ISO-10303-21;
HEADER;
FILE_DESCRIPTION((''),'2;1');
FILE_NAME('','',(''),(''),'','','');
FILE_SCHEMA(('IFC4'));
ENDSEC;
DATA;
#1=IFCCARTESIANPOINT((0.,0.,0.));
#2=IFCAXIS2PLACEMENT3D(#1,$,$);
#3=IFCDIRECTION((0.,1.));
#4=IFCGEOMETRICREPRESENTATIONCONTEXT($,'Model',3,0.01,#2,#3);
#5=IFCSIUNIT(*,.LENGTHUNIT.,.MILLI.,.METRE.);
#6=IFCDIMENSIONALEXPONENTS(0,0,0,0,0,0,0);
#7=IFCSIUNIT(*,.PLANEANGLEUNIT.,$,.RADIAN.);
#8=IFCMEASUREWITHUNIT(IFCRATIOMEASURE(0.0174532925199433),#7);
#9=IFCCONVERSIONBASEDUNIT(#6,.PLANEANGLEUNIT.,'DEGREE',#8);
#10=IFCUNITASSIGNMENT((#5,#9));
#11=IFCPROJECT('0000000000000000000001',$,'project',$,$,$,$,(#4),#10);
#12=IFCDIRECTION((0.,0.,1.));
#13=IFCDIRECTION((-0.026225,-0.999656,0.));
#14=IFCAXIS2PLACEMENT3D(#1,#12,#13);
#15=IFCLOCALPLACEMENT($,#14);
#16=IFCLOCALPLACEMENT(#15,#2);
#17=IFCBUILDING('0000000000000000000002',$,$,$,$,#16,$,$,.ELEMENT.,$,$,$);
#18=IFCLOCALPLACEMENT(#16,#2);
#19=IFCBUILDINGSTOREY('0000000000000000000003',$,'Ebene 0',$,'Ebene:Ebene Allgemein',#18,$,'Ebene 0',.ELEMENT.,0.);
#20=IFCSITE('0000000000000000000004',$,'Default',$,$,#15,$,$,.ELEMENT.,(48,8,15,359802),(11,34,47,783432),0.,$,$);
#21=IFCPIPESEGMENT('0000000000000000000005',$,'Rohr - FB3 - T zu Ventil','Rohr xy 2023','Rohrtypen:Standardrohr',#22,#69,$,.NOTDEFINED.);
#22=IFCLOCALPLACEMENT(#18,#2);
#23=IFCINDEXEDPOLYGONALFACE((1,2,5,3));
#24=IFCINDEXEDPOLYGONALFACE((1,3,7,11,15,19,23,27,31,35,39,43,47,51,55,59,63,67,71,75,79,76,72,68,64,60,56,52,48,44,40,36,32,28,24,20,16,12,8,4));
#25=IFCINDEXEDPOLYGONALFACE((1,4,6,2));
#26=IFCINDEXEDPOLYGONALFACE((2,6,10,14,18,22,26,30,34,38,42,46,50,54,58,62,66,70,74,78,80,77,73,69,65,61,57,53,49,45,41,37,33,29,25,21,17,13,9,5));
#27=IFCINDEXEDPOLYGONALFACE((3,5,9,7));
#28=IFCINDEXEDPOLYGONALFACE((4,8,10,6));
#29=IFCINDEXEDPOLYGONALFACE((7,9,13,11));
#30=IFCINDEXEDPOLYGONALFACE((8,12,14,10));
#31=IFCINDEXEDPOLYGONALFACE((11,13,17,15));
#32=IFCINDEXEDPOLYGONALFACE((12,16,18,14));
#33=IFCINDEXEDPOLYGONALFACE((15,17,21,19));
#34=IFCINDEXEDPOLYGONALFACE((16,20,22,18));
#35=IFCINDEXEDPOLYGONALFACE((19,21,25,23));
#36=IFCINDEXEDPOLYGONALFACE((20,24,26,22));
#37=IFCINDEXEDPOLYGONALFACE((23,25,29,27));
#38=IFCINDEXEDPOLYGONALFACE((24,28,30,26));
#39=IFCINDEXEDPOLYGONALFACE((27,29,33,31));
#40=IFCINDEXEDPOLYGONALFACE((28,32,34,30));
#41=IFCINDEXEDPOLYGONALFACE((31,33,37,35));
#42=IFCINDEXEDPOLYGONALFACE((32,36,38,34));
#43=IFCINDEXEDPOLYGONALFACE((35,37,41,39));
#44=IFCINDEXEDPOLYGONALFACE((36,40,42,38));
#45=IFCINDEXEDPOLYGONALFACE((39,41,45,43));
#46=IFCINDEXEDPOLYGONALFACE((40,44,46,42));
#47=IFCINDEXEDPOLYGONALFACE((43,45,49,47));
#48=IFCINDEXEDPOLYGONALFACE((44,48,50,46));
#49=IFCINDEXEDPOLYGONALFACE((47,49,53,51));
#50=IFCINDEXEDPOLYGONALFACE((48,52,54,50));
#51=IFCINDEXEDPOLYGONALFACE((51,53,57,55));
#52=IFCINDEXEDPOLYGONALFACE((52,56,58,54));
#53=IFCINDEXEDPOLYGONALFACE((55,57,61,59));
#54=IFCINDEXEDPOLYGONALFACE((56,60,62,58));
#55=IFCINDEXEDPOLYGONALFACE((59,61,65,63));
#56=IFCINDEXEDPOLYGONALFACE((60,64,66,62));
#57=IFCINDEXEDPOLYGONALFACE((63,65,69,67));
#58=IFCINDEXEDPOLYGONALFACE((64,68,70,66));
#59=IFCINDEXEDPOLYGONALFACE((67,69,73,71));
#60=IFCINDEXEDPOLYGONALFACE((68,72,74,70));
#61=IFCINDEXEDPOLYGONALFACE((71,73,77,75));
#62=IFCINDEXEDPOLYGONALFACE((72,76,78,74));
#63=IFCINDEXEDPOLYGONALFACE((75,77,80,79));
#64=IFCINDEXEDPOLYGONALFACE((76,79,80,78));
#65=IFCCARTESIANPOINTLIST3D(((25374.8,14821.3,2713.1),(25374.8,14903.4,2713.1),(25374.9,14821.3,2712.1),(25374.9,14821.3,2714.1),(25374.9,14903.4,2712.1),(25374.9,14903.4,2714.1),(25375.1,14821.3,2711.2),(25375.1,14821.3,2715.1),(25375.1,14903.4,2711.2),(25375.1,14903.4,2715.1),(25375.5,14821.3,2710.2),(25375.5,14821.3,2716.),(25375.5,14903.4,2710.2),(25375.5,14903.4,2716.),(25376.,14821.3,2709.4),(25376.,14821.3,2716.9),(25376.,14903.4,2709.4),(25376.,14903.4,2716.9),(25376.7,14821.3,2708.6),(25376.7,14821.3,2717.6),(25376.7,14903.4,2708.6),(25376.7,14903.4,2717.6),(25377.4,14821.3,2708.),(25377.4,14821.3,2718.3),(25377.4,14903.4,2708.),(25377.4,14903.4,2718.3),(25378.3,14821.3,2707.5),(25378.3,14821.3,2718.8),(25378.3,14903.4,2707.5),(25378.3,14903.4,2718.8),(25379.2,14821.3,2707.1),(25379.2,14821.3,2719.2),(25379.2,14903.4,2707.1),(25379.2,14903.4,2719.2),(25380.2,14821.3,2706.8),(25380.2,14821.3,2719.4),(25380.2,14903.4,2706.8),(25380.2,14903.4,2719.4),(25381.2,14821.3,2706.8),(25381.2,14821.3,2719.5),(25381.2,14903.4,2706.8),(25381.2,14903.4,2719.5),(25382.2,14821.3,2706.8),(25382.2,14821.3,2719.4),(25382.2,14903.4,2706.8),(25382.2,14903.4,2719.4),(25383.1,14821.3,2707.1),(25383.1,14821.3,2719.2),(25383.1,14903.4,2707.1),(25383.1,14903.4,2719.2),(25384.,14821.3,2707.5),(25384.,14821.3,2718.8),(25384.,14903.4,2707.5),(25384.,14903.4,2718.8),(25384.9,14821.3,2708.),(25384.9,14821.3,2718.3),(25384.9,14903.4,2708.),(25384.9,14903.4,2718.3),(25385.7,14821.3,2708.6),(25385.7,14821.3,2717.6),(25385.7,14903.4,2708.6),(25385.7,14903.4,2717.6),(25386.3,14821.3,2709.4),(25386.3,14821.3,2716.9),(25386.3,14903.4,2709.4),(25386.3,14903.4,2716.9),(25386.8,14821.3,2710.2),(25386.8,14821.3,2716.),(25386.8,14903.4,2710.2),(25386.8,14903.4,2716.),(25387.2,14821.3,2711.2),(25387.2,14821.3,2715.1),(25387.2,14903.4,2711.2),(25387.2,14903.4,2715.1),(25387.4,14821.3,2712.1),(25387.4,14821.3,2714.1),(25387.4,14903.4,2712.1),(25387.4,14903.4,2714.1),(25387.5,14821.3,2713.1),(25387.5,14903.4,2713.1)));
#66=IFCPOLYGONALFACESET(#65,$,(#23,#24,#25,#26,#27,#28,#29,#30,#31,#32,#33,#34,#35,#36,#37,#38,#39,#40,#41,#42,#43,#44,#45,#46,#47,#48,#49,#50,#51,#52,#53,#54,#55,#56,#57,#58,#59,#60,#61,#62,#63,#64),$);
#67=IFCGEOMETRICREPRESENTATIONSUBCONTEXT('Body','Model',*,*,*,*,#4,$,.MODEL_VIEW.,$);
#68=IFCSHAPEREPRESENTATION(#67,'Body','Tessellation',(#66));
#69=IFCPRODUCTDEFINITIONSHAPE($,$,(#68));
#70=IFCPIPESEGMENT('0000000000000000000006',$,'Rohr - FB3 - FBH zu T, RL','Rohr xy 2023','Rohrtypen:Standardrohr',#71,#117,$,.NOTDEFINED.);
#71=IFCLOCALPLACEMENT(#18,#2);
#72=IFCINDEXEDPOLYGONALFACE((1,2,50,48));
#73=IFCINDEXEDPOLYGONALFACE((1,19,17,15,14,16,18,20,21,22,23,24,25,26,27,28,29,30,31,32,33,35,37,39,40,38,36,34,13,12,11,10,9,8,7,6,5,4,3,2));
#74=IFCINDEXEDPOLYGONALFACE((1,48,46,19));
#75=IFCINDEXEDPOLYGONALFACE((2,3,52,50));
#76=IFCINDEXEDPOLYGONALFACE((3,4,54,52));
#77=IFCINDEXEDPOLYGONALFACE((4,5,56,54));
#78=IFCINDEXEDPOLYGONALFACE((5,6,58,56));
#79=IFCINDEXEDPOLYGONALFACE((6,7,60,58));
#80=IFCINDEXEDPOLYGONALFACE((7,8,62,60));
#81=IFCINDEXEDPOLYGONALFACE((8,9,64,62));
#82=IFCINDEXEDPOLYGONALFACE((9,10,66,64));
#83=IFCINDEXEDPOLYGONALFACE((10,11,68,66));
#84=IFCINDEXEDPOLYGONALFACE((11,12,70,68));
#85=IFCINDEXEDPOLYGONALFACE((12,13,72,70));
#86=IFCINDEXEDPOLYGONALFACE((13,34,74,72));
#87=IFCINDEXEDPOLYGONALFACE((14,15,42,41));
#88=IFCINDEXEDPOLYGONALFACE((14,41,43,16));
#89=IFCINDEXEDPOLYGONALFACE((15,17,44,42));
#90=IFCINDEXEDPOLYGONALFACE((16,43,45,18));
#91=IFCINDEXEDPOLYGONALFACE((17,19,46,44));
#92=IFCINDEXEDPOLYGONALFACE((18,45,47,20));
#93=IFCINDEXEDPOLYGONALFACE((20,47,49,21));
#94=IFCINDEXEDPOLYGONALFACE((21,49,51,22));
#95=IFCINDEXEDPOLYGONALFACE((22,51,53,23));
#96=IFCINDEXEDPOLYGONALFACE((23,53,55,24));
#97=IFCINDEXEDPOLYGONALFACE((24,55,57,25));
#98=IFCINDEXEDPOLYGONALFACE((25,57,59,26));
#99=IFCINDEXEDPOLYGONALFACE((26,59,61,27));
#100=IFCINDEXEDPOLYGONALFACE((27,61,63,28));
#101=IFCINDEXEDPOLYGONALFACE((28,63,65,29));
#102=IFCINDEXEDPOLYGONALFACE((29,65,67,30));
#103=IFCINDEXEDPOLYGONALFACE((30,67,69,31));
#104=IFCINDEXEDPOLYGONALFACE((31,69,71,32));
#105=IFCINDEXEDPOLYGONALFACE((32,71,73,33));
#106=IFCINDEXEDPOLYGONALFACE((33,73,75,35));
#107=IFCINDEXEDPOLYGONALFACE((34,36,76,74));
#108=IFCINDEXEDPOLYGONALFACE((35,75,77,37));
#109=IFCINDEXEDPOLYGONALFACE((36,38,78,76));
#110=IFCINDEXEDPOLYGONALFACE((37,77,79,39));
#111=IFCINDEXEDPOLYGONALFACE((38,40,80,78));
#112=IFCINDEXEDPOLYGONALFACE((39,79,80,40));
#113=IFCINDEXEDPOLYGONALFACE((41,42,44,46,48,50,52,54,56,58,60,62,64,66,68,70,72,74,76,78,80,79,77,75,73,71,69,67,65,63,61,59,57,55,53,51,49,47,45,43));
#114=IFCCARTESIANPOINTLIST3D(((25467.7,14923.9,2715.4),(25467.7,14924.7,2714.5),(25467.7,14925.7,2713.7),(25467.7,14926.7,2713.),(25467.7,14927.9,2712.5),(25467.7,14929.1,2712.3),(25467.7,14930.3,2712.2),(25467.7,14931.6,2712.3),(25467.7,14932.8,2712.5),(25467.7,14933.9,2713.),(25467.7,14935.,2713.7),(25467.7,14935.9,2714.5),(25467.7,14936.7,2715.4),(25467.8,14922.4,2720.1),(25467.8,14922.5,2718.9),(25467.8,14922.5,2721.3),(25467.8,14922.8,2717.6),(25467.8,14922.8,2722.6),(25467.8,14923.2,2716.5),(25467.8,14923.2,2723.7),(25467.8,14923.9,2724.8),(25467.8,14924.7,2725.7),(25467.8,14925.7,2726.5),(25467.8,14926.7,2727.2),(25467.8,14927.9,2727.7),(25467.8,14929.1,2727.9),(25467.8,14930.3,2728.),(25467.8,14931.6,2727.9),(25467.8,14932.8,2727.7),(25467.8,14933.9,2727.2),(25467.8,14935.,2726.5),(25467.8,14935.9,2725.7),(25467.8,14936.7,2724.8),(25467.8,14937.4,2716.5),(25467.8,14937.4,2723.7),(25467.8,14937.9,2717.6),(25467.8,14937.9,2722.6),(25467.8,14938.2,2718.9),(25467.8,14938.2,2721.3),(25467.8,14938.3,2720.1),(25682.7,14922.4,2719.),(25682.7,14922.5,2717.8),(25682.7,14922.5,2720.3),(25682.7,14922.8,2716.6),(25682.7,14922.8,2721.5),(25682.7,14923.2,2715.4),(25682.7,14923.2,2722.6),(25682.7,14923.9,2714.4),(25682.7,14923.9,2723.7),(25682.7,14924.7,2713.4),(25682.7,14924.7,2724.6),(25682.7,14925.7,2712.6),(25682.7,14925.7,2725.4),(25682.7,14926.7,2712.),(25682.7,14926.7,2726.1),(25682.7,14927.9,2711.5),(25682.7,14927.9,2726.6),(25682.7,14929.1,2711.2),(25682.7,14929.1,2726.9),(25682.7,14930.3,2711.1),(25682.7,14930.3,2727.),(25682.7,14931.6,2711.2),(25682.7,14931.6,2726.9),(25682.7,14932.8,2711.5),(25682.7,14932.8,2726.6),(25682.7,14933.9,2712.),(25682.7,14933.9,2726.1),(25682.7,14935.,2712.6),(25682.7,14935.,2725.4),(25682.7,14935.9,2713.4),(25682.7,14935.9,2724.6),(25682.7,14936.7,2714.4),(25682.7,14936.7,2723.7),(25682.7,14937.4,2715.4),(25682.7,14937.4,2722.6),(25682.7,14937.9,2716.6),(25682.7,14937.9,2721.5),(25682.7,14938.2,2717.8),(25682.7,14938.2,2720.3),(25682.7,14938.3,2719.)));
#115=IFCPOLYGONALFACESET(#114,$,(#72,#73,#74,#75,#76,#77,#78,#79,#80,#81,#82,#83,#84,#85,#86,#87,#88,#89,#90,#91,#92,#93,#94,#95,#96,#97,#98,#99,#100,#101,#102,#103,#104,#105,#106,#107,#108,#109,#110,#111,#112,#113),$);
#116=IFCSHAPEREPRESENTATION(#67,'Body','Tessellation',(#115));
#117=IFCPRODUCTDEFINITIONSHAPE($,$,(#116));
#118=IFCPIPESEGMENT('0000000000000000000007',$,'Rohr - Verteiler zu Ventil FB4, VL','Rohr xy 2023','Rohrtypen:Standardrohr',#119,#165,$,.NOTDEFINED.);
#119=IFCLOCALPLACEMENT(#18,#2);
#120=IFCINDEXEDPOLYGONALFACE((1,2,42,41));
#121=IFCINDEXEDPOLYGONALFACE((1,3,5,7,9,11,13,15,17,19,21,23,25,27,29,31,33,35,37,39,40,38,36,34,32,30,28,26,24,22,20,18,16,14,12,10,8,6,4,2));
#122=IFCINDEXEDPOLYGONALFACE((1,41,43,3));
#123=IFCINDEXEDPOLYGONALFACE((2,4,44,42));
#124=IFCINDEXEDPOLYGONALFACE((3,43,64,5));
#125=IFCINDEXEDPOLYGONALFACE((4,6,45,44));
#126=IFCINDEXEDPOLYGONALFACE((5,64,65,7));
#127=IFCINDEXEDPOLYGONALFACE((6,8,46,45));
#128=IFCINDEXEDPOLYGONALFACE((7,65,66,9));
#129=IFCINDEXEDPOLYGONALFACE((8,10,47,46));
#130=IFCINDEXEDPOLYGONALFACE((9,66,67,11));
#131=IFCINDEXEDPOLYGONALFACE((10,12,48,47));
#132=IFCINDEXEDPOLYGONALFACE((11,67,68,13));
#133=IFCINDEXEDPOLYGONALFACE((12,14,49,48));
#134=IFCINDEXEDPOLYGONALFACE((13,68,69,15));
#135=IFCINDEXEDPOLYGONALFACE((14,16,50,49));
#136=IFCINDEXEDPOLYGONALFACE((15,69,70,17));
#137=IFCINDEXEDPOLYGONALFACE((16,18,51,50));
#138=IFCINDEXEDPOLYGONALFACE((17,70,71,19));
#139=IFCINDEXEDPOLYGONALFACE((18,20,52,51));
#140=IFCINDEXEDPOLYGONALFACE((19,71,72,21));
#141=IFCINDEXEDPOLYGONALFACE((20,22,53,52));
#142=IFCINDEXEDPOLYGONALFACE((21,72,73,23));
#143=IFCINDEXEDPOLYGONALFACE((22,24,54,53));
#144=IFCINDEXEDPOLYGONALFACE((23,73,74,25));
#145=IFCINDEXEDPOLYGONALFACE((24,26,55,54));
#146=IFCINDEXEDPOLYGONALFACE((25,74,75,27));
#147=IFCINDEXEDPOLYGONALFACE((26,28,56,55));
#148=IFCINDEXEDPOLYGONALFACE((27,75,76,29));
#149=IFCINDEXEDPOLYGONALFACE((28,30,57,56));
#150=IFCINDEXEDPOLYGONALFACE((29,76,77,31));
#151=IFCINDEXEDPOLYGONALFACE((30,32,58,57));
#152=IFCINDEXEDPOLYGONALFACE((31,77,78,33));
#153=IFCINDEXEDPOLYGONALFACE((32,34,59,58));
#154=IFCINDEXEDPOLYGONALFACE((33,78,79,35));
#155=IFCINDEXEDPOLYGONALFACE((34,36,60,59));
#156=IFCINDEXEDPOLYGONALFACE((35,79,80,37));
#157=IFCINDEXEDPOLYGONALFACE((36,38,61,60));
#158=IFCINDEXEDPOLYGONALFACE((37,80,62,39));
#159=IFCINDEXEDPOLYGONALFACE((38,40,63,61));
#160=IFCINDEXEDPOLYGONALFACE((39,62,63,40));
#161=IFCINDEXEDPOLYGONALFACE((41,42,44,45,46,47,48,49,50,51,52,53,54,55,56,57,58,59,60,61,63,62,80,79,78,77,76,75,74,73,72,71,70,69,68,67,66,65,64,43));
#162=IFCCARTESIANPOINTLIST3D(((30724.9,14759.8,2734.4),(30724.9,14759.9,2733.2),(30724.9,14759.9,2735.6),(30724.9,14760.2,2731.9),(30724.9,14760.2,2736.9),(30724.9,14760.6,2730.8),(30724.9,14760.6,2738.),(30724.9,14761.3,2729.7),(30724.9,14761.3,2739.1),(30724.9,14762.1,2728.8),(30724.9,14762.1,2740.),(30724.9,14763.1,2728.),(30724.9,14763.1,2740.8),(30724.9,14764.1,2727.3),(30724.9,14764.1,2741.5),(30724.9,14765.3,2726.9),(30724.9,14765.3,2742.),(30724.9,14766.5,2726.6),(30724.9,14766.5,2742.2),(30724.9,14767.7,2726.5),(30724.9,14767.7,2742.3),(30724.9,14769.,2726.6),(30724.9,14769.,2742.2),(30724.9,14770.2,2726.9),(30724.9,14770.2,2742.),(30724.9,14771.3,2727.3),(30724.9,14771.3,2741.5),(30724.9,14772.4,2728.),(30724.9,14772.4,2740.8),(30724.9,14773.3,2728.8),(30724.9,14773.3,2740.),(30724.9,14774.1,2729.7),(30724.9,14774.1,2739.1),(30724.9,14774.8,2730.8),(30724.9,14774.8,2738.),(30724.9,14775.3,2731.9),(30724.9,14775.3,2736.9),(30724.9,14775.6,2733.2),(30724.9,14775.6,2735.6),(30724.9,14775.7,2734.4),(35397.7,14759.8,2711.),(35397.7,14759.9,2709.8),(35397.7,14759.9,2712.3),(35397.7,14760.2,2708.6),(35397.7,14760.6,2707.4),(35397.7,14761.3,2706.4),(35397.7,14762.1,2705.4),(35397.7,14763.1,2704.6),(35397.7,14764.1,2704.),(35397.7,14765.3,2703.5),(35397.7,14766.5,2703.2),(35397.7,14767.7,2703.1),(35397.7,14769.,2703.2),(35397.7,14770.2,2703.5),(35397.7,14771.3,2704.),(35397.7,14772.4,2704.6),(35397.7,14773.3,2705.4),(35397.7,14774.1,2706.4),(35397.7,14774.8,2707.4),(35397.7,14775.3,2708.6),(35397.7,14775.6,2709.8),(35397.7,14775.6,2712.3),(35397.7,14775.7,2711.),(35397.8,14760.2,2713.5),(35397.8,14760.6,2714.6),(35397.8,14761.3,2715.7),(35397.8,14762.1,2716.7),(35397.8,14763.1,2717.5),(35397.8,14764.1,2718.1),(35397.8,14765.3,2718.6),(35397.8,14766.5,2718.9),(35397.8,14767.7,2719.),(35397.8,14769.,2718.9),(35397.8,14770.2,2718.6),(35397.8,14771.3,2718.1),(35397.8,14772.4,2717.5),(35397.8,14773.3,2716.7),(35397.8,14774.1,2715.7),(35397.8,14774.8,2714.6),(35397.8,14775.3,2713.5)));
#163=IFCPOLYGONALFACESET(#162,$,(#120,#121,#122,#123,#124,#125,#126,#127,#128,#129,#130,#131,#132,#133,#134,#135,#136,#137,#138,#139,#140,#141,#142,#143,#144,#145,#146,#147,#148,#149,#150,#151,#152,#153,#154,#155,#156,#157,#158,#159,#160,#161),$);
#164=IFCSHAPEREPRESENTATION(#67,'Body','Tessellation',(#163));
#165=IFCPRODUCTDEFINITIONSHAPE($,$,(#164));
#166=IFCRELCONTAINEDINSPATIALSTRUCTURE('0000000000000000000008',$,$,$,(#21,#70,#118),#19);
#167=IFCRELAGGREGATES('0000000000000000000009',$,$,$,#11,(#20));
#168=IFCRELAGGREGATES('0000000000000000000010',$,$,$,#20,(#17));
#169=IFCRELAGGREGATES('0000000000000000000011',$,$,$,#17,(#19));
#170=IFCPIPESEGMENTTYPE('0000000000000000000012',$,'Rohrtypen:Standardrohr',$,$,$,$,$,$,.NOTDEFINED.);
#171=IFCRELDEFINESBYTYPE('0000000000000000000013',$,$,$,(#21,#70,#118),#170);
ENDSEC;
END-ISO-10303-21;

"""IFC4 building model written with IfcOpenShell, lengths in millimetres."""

from ifc_helpers import new_model, entity, si_unit, converted_unit, direction, frame, origin, place, context, subcontext, project, spatial, indexed_curve, outline, extrude, type_object, element, save


model = new_model("IFC4")

# Units and contexts
model_context = context("Model", 3, precision=0.01, world=origin(), true_north=direction((0.0, 1.0)))
body_context = subcontext(model_context, "Body", "Model", "MODEL_VIEW")
ifc_project = project(units=[si_unit("LENGTHUNIT", "METRE", prefix="MILLI"), converted_unit("PLANEANGLEUNIT", "DEGREE", entity("IfcRatioMeasure", 0.0174532925199433), si_unit("PLANEANGLEUNIT", "RADIAN"), dimensions=[0, 0, 0, 0, 0, 0, 0])], contexts=[model_context])

# Site, building, storey
site_placement = place(None, frame((0.0, 0.0, 0.0), z_axis=(0.0, 0.0, 1.0), x_axis=(-0.026225, -0.999656, 0.0)))
site = spatial("IfcSite", under=ifc_project, at=site_placement, Name="Default", CompositionType="ELEMENT", RefLatitude=(48, 8, 15, 359802), RefLongitude=(11, 34, 47, 783432), RefElevation=0.0)
building_placement = place(site_placement, origin())
building = spatial("IfcBuilding", under=site, at=building_placement, CompositionType="ELEMENT")
storey_placement = place(building_placement, origin())
storey = spatial("IfcBuildingStorey", under=building, at=storey_placement, Name="Ebene 0", ObjectType="Ebene:Ebene Allgemein", LongName="Ebene 0", CompositionType="ELEMENT", Elevation=0.0)

# Pipe segments
pipe_segment_type = type_object("IfcPipeSegmentType", Name="Rohrtypen:Standardrohr", PredefinedType="NOTDEFINED")
pipe_segment_1_placement = place(storey_placement, origin())
element("IfcPipeSegment", 1, at=pipe_segment_1_placement, inside=storey, type_object=pipe_segment_type, Name="Rohr - FB3 - T zu Ventil", Description="Rohr xy 2023", ObjectType="Rohrtypen:Standardrohr", PredefinedType="NOTDEFINED", context=body_context, shape_type="SweptSolid", body=[
    extrude(outline(indexed_curve([(6.3, 0.0), (6.3, 1.0), (6.0, 2.0), (5.7, 2.9), (5.1, 3.7), (4.5, 4.5), (3.7, 5.1), (2.9, 5.7), (2.0, 6.0), (1.0, 6.3), (0.0, 6.4), (-1.0, 6.3), (-2.0, 6.0), (-2.9, 5.7), (-3.7, 5.1), (-4.5, 4.5), (-5.1, 3.7), (-5.7, 2.9), (-6.0, 2.0), (-6.3, 1.0), (-6.3, 0.0), (-6.3, -1.0), (-6.0, -2.0), (-5.7, -2.9), (-5.1, -3.7), (-4.5, -4.5), (-3.7, -5.1), (-2.9, -5.7), (-2.0, -6.0), (-1.0, -6.3), (0.0, -6.4), (1.0, -6.3), (2.0, -6.0), (2.9, -5.7), (3.7, -5.1), (4.5, -4.5), (5.1, -3.7), (5.7, -2.9), (6.0, -2.0), (6.3, -1.0), (6.3, 0.0)], self_intersect=False)), frame((25381.2, 14821.3, 2713.1), z_axis=(0.0, 1.0, 0.0), x_axis=(-1.0, 0.0, 0.0)), (0.0, 0.0, 1.0), 82.2),
])
pipe_segment_2_placement = place(storey_placement, origin())
element("IfcPipeSegment", 2, at=pipe_segment_2_placement, inside=storey, type_object=pipe_segment_type, Name="Rohr - FB3 - FBH zu T, RL", Description="Rohr xy 2023", ObjectType="Rohrtypen:Standardrohr", PredefinedType="NOTDEFINED", context=body_context, shape_type="SweptSolid", body=[
    extrude(outline(indexed_curve([(7.9, 0.0), (7.8, 1.2), (7.6, 2.5), (7.1, 3.6), (6.4, 4.7), (5.6, 5.6), (4.7, 6.4), (3.6, 7.1), (2.5, 7.6), (1.2, 7.8), (0.0, 7.9), (-1.2, 7.8), (-2.5, 7.6), (-3.6, 7.1), (-4.7, 6.4), (-5.6, 5.6), (-6.4, 4.7), (-7.1, 3.6), (-7.6, 2.5), (-7.8, 1.2), (-7.9, 0.0), (-7.8, -1.2), (-7.6, -2.5), (-7.1, -3.6), (-6.4, -4.7), (-5.6, -5.6), (-4.7, -6.4), (-3.6, -7.1), (-2.5, -7.6), (-1.2, -7.8), (0.0, -7.9), (1.2, -7.8), (2.5, -7.6), (3.6, -7.1), (4.7, -6.4), (5.6, -5.6), (6.4, -4.7), (7.1, -3.6), (7.6, -2.5), (7.8, -1.2), (7.9, 0.0)], self_intersect=False)), frame((25682.7, 14930.3, 2719.0), z_axis=(-0.999988, 0.0, 0.005), x_axis=(0.0, 1.0, 0.0)), (0.0, 0.0, 1.0), 214.9),
])
pipe_segment_3_placement = place(storey_placement, origin())
element("IfcPipeSegment", 3, at=pipe_segment_3_placement, inside=storey, type_object=pipe_segment_type, Name="Rohr - Verteiler zu Ventil FB4, VL", Description="Rohr xy 2023", ObjectType="Rohrtypen:Standardrohr", PredefinedType="NOTDEFINED", context=body_context, shape_type="SweptSolid", body=[
    extrude(outline(indexed_curve([(7.9, 0.0), (7.8, 1.2), (7.6, 2.5), (7.1, 3.6), (6.4, 4.7), (5.6, 5.6), (4.7, 6.4), (3.6, 7.1), (2.5, 7.6), (1.2, 7.8), (0.0, 7.9), (-1.2, 7.8), (-2.5, 7.6), (-3.6, 7.1), (-4.7, 6.4), (-5.6, 5.6), (-6.4, 4.7), (-7.1, 3.6), (-7.6, 2.5), (-7.8, 1.2), (-7.9, 0.0), (-7.8, -1.2), (-7.6, -2.5), (-7.1, -3.6), (-6.4, -4.7), (-5.6, -5.6), (-4.7, -6.4), (-3.6, -7.1), (-2.5, -7.6), (-1.2, -7.8), (0.0, -7.9), (1.2, -7.8), (2.5, -7.6), (3.6, -7.1), (4.7, -6.4), (5.6, -5.6), (6.4, -4.7), (7.1, -3.6), (7.6, -2.5), (7.8, -1.2), (7.9, 0.0)], self_intersect=False)), frame((35397.7, 14767.7, 2711.0), z_axis=(-0.999988, 0.0, 0.005), x_axis=(0.0, 1.0, 0.0)), (0.0, 0.0, 1.0), 4672.9),
])

save(model, "model.ifc")
